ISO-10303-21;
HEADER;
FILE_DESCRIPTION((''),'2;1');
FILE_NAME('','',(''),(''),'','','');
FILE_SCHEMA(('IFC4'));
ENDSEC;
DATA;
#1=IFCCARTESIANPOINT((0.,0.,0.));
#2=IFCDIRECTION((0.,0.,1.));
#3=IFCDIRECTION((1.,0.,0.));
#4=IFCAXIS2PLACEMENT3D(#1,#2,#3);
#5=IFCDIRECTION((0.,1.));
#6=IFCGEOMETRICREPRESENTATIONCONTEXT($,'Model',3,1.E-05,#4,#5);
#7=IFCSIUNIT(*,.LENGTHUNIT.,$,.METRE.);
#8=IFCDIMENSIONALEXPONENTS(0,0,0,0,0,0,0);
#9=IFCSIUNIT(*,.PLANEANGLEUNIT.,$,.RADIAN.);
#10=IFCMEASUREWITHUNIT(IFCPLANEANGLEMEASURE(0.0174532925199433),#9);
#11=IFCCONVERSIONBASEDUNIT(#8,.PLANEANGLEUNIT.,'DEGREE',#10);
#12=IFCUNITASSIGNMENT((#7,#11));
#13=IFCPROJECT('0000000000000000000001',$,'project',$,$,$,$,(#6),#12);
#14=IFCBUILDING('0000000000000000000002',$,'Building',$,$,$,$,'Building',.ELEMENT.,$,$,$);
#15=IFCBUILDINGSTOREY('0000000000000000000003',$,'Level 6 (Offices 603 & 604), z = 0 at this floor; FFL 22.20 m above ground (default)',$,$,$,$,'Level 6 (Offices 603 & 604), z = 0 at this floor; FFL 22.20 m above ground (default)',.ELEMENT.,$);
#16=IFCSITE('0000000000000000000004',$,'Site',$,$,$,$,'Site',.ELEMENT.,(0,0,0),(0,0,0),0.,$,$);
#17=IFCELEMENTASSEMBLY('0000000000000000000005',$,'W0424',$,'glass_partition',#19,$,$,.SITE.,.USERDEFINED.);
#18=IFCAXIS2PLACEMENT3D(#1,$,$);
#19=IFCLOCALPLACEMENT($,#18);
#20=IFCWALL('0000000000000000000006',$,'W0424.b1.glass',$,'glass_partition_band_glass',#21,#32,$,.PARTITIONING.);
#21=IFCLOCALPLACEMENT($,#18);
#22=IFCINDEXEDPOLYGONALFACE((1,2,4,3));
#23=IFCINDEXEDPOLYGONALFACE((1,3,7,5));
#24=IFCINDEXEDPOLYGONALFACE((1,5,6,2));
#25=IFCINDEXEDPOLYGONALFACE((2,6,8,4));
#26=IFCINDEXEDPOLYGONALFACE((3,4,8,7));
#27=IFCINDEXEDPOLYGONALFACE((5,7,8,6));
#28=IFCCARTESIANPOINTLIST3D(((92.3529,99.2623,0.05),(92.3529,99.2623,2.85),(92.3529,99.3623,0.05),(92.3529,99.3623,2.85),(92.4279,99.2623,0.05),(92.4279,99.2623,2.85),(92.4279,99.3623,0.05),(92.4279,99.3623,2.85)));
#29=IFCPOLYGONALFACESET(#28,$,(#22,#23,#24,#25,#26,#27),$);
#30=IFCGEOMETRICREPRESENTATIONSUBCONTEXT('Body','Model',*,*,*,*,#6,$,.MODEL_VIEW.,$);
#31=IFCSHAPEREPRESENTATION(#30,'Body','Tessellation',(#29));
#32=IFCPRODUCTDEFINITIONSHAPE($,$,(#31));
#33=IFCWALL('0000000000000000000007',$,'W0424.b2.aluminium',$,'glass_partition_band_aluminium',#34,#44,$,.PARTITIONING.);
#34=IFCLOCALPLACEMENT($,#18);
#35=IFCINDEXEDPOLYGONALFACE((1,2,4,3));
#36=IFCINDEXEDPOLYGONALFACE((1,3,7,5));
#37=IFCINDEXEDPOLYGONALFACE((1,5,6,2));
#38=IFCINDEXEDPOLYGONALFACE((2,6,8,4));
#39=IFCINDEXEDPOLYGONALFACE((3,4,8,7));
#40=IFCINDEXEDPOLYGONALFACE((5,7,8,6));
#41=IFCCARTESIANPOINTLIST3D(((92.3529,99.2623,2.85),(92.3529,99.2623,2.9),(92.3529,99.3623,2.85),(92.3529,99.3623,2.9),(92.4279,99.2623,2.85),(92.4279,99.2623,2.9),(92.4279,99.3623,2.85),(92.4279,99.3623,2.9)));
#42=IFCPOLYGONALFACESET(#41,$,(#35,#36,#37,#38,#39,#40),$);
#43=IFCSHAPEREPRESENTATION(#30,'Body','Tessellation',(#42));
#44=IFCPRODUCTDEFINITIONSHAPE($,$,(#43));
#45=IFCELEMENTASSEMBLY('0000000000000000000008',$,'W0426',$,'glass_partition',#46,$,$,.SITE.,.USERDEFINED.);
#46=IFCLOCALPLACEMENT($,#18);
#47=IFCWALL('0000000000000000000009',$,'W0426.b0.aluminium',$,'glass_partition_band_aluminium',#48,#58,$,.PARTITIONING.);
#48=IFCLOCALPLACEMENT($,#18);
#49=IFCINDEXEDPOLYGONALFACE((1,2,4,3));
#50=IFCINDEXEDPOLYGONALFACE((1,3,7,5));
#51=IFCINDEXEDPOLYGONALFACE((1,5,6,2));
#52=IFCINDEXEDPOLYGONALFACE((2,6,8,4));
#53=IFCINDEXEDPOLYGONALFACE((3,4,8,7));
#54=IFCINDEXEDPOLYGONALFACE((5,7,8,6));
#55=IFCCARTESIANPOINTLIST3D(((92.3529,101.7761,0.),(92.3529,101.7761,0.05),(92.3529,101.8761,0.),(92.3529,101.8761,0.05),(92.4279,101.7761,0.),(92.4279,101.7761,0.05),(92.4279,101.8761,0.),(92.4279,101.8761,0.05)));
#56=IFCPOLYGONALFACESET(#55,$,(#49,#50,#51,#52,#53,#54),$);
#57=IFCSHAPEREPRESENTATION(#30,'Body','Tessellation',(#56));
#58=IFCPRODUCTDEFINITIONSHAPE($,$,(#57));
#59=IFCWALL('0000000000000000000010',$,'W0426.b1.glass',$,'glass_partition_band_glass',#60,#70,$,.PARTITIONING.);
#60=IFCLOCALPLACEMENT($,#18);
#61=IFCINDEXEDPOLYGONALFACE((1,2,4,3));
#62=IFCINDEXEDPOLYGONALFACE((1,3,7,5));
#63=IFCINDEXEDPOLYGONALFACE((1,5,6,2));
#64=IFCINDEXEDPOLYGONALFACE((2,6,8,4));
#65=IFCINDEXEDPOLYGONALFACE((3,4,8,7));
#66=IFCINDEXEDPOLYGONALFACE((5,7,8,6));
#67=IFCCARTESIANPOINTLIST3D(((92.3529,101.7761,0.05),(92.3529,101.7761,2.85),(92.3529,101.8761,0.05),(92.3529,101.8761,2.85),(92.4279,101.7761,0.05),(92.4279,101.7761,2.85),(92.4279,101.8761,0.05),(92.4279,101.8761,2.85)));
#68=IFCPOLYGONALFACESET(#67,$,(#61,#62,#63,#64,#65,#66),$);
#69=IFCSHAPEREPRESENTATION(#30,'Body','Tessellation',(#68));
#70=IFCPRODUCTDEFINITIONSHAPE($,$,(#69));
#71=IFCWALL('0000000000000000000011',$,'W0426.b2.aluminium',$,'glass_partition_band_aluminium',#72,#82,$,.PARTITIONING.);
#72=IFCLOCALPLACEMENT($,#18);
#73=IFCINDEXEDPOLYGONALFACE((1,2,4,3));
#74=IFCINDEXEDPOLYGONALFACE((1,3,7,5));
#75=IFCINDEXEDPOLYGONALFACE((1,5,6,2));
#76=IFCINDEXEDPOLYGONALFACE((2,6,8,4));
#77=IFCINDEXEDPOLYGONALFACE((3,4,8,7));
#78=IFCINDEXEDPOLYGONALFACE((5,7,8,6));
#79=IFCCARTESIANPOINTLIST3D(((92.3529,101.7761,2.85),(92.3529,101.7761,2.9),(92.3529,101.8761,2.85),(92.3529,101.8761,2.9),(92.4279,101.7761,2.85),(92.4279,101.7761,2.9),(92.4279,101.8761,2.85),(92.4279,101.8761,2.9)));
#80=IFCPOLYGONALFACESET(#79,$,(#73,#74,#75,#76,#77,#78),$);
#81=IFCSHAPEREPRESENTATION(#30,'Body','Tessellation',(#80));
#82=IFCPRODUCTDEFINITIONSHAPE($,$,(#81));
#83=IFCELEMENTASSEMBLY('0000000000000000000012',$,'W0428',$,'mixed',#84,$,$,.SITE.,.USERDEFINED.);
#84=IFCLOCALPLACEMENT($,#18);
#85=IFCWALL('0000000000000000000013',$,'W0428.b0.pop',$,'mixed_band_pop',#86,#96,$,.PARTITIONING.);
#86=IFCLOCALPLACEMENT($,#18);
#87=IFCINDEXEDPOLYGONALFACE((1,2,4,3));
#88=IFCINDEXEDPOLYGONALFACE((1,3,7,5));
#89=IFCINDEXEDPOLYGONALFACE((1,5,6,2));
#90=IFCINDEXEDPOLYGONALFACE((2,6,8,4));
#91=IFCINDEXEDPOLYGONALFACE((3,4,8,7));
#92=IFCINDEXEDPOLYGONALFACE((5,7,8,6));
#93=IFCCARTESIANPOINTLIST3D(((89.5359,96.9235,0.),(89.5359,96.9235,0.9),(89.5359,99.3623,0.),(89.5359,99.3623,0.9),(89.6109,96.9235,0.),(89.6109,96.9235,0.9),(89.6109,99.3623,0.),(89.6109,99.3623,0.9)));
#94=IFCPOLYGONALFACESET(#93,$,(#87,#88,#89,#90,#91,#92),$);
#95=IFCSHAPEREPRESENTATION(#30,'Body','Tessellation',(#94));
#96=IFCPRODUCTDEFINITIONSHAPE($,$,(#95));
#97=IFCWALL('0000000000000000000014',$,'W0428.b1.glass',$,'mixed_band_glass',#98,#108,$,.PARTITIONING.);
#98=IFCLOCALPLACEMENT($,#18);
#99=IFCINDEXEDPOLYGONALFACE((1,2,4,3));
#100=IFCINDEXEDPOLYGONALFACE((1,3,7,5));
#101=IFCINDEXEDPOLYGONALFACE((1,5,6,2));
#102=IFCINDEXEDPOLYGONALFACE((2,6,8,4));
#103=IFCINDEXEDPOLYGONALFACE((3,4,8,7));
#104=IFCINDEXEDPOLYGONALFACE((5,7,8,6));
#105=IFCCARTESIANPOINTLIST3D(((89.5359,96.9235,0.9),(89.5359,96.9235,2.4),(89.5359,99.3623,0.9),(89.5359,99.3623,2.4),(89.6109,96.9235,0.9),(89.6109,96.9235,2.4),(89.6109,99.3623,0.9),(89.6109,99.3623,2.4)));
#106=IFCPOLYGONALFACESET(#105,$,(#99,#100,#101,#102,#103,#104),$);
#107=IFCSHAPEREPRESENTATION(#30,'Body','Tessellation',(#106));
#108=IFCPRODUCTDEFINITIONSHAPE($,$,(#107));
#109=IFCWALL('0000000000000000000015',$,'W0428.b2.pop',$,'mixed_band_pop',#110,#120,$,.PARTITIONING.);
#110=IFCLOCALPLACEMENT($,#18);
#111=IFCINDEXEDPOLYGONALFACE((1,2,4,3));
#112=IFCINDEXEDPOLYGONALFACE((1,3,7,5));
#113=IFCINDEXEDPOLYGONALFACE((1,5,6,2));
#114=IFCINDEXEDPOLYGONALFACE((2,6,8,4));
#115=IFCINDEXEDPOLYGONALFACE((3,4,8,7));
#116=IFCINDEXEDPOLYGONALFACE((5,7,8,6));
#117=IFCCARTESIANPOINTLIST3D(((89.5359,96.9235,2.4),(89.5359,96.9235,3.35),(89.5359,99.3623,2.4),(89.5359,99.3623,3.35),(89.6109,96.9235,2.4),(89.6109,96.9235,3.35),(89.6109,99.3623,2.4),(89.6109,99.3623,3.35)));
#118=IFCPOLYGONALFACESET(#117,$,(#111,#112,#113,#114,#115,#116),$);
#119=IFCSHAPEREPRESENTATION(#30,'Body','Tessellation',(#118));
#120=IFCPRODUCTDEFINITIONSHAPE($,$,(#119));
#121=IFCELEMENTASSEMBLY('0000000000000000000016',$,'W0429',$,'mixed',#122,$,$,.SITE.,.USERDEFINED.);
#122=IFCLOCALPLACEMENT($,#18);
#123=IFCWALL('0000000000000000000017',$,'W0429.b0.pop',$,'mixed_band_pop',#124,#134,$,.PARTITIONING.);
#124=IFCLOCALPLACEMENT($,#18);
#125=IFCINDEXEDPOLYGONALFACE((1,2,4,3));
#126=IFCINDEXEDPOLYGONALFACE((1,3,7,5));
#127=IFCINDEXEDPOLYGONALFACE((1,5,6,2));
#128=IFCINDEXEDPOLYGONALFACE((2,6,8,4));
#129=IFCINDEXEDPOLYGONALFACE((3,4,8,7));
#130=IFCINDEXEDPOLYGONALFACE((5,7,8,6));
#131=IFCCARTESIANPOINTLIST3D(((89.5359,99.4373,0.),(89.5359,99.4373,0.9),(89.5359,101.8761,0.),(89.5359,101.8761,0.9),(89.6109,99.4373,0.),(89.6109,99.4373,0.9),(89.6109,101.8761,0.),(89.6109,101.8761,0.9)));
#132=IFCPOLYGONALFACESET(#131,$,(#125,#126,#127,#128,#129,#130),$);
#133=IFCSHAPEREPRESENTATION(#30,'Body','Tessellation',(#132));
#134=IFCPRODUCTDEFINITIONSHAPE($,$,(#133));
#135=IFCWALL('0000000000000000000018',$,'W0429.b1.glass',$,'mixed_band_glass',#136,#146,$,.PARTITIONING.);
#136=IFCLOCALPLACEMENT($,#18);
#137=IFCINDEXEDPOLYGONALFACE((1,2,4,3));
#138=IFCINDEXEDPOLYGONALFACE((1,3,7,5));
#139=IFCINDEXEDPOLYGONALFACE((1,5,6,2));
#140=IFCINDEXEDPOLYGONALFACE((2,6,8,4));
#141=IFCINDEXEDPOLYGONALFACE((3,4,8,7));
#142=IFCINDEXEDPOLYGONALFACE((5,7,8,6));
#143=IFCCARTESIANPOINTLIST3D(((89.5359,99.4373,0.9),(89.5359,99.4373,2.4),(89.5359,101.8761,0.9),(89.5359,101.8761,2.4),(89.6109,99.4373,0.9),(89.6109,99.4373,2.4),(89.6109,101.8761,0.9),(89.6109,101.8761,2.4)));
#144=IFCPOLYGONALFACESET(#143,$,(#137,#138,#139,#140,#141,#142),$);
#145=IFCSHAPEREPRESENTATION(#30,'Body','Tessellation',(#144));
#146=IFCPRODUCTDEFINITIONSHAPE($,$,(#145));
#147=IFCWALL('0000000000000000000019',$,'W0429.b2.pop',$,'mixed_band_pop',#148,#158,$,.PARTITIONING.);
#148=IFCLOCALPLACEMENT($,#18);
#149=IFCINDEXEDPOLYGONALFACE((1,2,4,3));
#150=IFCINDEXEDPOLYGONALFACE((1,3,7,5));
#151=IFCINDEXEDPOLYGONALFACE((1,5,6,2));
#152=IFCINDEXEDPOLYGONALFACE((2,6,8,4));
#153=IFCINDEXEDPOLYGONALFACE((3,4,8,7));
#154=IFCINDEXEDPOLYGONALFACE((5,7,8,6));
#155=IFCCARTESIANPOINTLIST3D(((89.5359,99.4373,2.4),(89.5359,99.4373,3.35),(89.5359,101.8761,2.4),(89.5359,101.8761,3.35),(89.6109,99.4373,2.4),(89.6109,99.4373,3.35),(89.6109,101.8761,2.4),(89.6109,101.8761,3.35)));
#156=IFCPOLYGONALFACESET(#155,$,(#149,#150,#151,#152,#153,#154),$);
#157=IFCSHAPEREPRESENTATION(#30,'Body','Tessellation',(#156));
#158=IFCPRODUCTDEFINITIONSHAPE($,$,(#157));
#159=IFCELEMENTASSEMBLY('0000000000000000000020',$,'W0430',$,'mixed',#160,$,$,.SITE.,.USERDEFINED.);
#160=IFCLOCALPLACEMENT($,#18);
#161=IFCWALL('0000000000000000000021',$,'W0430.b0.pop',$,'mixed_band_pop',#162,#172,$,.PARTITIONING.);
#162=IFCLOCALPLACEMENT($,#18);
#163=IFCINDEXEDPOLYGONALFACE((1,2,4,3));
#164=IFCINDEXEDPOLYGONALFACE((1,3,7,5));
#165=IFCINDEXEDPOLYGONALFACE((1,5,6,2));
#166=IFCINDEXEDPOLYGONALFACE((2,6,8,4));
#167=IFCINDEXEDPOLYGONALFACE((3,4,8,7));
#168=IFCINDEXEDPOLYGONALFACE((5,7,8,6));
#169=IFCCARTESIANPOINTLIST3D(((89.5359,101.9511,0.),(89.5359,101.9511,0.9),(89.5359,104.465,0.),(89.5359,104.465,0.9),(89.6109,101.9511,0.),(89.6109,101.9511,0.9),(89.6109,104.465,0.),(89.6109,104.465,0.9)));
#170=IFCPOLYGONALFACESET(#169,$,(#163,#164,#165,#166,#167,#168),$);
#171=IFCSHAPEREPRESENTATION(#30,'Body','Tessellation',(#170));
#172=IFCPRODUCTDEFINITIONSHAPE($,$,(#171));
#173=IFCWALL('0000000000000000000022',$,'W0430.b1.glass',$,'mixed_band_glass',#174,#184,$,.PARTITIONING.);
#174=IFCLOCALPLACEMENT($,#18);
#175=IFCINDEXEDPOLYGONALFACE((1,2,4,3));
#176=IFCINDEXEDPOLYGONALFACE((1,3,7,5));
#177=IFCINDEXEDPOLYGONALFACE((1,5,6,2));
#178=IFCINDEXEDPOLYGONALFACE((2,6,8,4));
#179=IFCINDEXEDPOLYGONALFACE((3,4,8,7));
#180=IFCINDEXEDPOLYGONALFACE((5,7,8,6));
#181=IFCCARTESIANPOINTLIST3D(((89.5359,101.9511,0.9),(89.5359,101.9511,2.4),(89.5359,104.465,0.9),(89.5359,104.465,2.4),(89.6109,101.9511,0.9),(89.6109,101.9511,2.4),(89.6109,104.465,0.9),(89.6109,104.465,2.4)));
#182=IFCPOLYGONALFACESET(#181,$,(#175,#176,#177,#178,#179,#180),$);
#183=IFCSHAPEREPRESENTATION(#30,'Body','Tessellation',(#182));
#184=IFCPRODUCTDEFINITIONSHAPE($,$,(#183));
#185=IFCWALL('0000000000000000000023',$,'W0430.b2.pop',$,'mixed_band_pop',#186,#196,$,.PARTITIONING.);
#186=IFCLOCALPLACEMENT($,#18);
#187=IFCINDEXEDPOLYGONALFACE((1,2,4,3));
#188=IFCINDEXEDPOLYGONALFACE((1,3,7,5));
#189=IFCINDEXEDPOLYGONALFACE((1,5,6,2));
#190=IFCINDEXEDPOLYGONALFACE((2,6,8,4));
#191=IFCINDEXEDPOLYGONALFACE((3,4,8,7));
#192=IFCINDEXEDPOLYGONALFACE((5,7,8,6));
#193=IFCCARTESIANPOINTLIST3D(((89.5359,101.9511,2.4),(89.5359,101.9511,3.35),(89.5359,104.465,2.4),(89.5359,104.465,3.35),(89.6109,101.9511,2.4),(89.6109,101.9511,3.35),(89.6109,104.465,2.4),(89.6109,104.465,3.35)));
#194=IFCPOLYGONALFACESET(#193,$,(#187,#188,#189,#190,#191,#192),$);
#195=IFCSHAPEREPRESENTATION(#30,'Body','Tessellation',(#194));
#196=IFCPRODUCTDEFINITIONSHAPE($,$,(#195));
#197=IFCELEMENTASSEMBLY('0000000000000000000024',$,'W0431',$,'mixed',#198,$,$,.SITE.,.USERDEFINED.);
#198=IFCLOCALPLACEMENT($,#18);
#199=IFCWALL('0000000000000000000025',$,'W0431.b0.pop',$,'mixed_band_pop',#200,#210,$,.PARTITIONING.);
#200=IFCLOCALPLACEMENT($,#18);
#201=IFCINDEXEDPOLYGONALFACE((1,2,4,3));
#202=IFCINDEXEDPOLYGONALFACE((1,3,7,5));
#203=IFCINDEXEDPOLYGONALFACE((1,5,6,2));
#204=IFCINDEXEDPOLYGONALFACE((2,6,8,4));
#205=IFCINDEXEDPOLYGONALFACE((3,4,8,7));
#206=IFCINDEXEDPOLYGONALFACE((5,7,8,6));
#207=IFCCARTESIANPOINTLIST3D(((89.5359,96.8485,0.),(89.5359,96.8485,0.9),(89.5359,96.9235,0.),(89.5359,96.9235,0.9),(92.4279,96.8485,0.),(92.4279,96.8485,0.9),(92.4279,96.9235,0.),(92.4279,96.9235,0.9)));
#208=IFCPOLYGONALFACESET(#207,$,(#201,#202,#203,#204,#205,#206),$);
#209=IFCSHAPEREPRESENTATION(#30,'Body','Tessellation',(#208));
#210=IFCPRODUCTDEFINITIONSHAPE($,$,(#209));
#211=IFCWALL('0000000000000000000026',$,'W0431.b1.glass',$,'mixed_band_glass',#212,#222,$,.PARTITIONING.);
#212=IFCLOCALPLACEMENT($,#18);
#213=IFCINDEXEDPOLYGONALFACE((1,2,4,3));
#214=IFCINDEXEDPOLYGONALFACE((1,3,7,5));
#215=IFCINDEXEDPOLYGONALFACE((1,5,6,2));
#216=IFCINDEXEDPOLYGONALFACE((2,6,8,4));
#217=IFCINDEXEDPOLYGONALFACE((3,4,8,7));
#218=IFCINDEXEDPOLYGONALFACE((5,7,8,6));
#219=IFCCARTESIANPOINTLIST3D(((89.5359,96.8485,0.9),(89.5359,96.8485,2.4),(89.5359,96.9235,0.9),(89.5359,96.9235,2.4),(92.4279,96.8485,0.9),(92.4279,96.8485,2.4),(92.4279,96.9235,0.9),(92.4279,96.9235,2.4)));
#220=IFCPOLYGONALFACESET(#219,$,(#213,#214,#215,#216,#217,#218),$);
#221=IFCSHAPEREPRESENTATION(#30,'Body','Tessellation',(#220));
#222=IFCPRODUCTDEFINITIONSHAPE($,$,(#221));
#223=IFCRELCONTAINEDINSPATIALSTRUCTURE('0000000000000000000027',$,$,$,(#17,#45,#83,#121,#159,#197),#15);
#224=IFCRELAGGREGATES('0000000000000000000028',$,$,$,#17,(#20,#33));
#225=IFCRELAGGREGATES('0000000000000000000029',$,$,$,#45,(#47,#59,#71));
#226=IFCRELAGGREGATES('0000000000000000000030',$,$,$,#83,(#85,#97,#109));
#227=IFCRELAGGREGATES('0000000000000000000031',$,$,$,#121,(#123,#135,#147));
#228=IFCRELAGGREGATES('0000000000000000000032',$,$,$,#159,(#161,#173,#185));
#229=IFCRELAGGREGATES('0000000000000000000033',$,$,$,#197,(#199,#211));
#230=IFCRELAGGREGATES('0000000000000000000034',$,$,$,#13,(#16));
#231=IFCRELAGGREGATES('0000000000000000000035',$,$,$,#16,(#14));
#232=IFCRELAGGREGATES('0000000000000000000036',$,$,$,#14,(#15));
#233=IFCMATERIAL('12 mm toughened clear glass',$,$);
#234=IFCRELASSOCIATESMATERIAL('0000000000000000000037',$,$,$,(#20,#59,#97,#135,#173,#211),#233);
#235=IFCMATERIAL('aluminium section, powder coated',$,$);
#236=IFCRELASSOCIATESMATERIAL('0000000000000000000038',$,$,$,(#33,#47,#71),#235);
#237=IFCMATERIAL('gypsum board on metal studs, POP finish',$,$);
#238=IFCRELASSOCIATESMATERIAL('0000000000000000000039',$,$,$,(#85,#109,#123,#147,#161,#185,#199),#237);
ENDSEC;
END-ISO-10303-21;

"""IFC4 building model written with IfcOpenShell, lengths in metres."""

from ifc_helpers import new_model, entity, si_unit, converted_unit, direction, frame, frame_2d, origin_with_axes, place, context, subcontext, project, spatial, rectangle, extrude, material, element, aggregate, save


model = new_model("IFC4")

# Units and contexts
model_context = context("Model", 3, precision=1e-05, world=origin_with_axes(), true_north=direction((0.0, 1.0)))
body_context = subcontext(model_context, "Body", "Model", "MODEL_VIEW")
ifc_project = project(units=[si_unit("LENGTHUNIT", "METRE"), converted_unit("PLANEANGLEUNIT", "DEGREE", entity("IfcPlaneAngleMeasure", 0.0174532925199433), si_unit("PLANEANGLEUNIT", "RADIAN"), dimensions=[0, 0, 0, 0, 0, 0, 0])], contexts=[model_context])

# Site, building, storey
site = spatial("IfcSite", under=ifc_project, Name="Site", LongName="Site", CompositionType="ELEMENT", RefLatitude=(0, 0, 0), RefLongitude=(0, 0, 0), RefElevation=0.0)
building = spatial("IfcBuilding", under=site, Name="Building", LongName="Building", CompositionType="ELEMENT")
storey = spatial("IfcBuildingStorey", under=building, Name="Level 6 (Offices 603 & 604), z = 0 at this floor; FFL 22.20 m above ground (default)", LongName="Level 6 (Offices 603 & 604), z = 0 at this floor; FFL 22.20 m above ground (default)", CompositionType="ELEMENT")

# Element assemblies, walls
assembly_1 = element("IfcElementAssembly", 1, inside=storey, Name="W0424", ObjectType="glass_partition", AssemblyPlace="SITE", PredefinedType="USERDEFINED")
ifc_material_1 = material(Name="12 mm toughened clear glass")
placement = place(None, origin_with_axes())
wall_1 = element("IfcWall", 2, at=placement, material=ifc_material_1, Name="W0424.b1.glass", ObjectType="glass_partition_band_glass", PredefinedType="PARTITIONING", context=body_context, shape_type="SweptSolid", body=[
    extrude(rectangle(XDim=0.1, YDim=0.075, at=frame_2d((0.0, 0.0), x_axis=(0.0, 1.0))), frame((92.3904, 99.3123, 0.05), z_axis=(0.0, 0.0, 1.0), x_axis=(1.0, 0.0, 0.0)), (0.0, 0.0, 1.0), 2.8),
])
ifc_material_2 = material(Name="aluminium section, powder coated")
wall_2 = element("IfcWall", 3, at=placement, material=ifc_material_2, Name="W0424.b2.aluminium", ObjectType="glass_partition_band_aluminium", PredefinedType="PARTITIONING", context=body_context, shape_type="SweptSolid", body=[
    extrude(rectangle(XDim=0.1, YDim=0.075, at=frame_2d((0.0, 0.0), x_axis=(0.0, 1.0))), frame((92.3904, 99.3123, 2.85), z_axis=(0.0, 0.0, 1.0), x_axis=(1.0, 0.0, 0.0)), (0.0, 0.0, 1.0), 0.05),
])
aggregate(assembly_1, [wall_1, wall_2])
assembly_2 = element("IfcElementAssembly", 4, inside=storey, Name="W0426", ObjectType="glass_partition", AssemblyPlace="SITE", PredefinedType="USERDEFINED")
wall_3 = element("IfcWall", 5, at=placement, material=ifc_material_2, Name="W0426.b0.aluminium", ObjectType="glass_partition_band_aluminium", PredefinedType="PARTITIONING", context=body_context, shape_type="SweptSolid", body=[
    extrude(rectangle(XDim=0.1, YDim=0.075, at=frame_2d((0.0, 0.0), x_axis=(0.0, 1.0))), frame((92.3904, 101.8261, 0.0), z_axis=(0.0, 0.0, 1.0), x_axis=(1.0, 0.0, 0.0)), (0.0, 0.0, 1.0), 0.05),
])
wall_4 = element("IfcWall", 6, at=placement, material=ifc_material_1, Name="W0426.b1.glass", ObjectType="glass_partition_band_glass", PredefinedType="PARTITIONING", context=body_context, shape_type="SweptSolid", body=[
    extrude(rectangle(XDim=0.1, YDim=0.075, at=frame_2d((0.0, 0.0), x_axis=(0.0, 1.0))), frame((92.3904, 101.8261, 0.05), z_axis=(0.0, 0.0, 1.0), x_axis=(1.0, 0.0, 0.0)), (0.0, 0.0, 1.0), 2.8),
])
wall_5 = element("IfcWall", 7, at=placement, material=ifc_material_2, Name="W0426.b2.aluminium", ObjectType="glass_partition_band_aluminium", PredefinedType="PARTITIONING", context=body_context, shape_type="SweptSolid", body=[
    extrude(rectangle(XDim=0.1, YDim=0.075, at=frame_2d((0.0, 0.0), x_axis=(0.0, 1.0))), frame((92.3904, 101.8261, 2.85), z_axis=(0.0, 0.0, 1.0), x_axis=(1.0, 0.0, 0.0)), (0.0, 0.0, 1.0), 0.05),
])
aggregate(assembly_2, [wall_3, wall_4, wall_5])
assembly_3 = element("IfcElementAssembly", 8, inside=storey, Name="W0428", ObjectType="mixed", AssemblyPlace="SITE", PredefinedType="USERDEFINED")
ifc_material_3 = material(Name="gypsum board on metal studs, POP finish")
wall_6 = element("IfcWall", 9, at=placement, material=ifc_material_3, Name="W0428.b0.pop", ObjectType="mixed_band_pop", PredefinedType="PARTITIONING", context=body_context, shape_type="SweptSolid", body=[
    extrude(rectangle(XDim=2.4388, YDim=0.075, at=frame_2d((0.0, 0.0), x_axis=(0.0, 1.0))), frame((89.5734, 98.1429, 0.0), z_axis=(0.0, 0.0, 1.0), x_axis=(1.0, 0.0, 0.0)), (0.0, 0.0, 1.0), 0.9),
])
wall_7 = element("IfcWall", 10, at=placement, material=ifc_material_1, Name="W0428.b1.glass", ObjectType="mixed_band_glass", PredefinedType="PARTITIONING", context=body_context, shape_type="SweptSolid", body=[
    extrude(rectangle(XDim=2.4388, YDim=0.075, at=frame_2d((0.0, 0.0), x_axis=(0.0, 1.0))), frame((89.5734, 98.1429, 0.9), z_axis=(0.0, 0.0, 1.0), x_axis=(1.0, 0.0, 0.0)), (0.0, 0.0, 1.0), 1.5),
])
wall_8 = element("IfcWall", 11, at=placement, material=ifc_material_3, Name="W0428.b2.pop", ObjectType="mixed_band_pop", PredefinedType="PARTITIONING", context=body_context, shape_type="SweptSolid", body=[
    extrude(rectangle(XDim=2.4388, YDim=0.075, at=frame_2d((0.0, 0.0), x_axis=(0.0, 1.0))), frame((89.5734, 98.1429, 2.4), z_axis=(0.0, 0.0, 1.0), x_axis=(1.0, 0.0, 0.0)), (0.0, 0.0, 1.0), 0.95),
])
aggregate(assembly_3, [wall_6, wall_7, wall_8])
assembly_4 = element("IfcElementAssembly", 12, inside=storey, Name="W0429", ObjectType="mixed", AssemblyPlace="SITE", PredefinedType="USERDEFINED")
wall_9 = element("IfcWall", 13, at=placement, material=ifc_material_3, Name="W0429.b0.pop", ObjectType="mixed_band_pop", PredefinedType="PARTITIONING", context=body_context, shape_type="SweptSolid", body=[
    extrude(rectangle(XDim=2.4388, YDim=0.075, at=frame_2d((0.0, 0.0), x_axis=(0.0, 1.0))), frame((89.5734, 100.6567, 0.0), z_axis=(0.0, 0.0, 1.0), x_axis=(1.0, 0.0, 0.0)), (0.0, 0.0, 1.0), 0.9),
])
wall_10 = element("IfcWall", 14, at=placement, material=ifc_material_1, Name="W0429.b1.glass", ObjectType="mixed_band_glass", PredefinedType="PARTITIONING", context=body_context, shape_type="SweptSolid", body=[
    extrude(rectangle(XDim=2.4388, YDim=0.075, at=frame_2d((0.0, 0.0), x_axis=(0.0, 1.0))), frame((89.5734, 100.6567, 0.9), z_axis=(0.0, 0.0, 1.0), x_axis=(1.0, 0.0, 0.0)), (0.0, 0.0, 1.0), 1.5),
])
wall_11 = element("IfcWall", 15, at=placement, material=ifc_material_3, Name="W0429.b2.pop", ObjectType="mixed_band_pop", PredefinedType="PARTITIONING", context=body_context, shape_type="SweptSolid", body=[
    extrude(rectangle(XDim=2.4388, YDim=0.075, at=frame_2d((0.0, 0.0), x_axis=(0.0, 1.0))), frame((89.5734, 100.6567, 2.4), z_axis=(0.0, 0.0, 1.0), x_axis=(1.0, 0.0, 0.0)), (0.0, 0.0, 1.0), 0.95),
])
aggregate(assembly_4, [wall_9, wall_10, wall_11])
assembly_5 = element("IfcElementAssembly", 16, inside=storey, Name="W0430", ObjectType="mixed", AssemblyPlace="SITE", PredefinedType="USERDEFINED")
wall_12 = element("IfcWall", 17, at=placement, material=ifc_material_3, Name="W0430.b0.pop", ObjectType="mixed_band_pop", PredefinedType="PARTITIONING", context=body_context, shape_type="SweptSolid", body=[
    extrude(rectangle(XDim=2.5139, YDim=0.075, at=frame_2d((0.0, 0.0), x_axis=(0.0, 1.0))), frame((89.5734, 103.2081, 0.0), z_axis=(0.0, 0.0, 1.0), x_axis=(1.0, 0.0, 0.0)), (0.0, 0.0, 1.0), 0.9),
])
wall_13 = element("IfcWall", 18, at=placement, material=ifc_material_1, Name="W0430.b1.glass", ObjectType="mixed_band_glass", PredefinedType="PARTITIONING", context=body_context, shape_type="SweptSolid", body=[
    extrude(rectangle(XDim=2.5139, YDim=0.075, at=frame_2d((0.0, 0.0), x_axis=(0.0, 1.0))), frame((89.5734, 103.2081, 0.9), z_axis=(0.0, 0.0, 1.0), x_axis=(1.0, 0.0, 0.0)), (0.0, 0.0, 1.0), 1.5),
])
wall_14 = element("IfcWall", 19, at=placement, material=ifc_material_3, Name="W0430.b2.pop", ObjectType="mixed_band_pop", PredefinedType="PARTITIONING", context=body_context, shape_type="SweptSolid", body=[
    extrude(rectangle(XDim=2.5139, YDim=0.075, at=frame_2d((0.0, 0.0), x_axis=(0.0, 1.0))), frame((89.5734, 103.2081, 2.4), z_axis=(0.0, 0.0, 1.0), x_axis=(1.0, 0.0, 0.0)), (0.0, 0.0, 1.0), 0.95),
])
aggregate(assembly_5, [wall_12, wall_13, wall_14])
assembly_6 = element("IfcElementAssembly", 20, inside=storey, Name="W0431", ObjectType="mixed", AssemblyPlace="SITE", PredefinedType="USERDEFINED")
wall_15 = element("IfcWall", 21, at=placement, material=ifc_material_3, Name="W0431.b0.pop", ObjectType="mixed_band_pop", PredefinedType="PARTITIONING", context=body_context, shape_type="SweptSolid", body=[
    extrude(rectangle(XDim=2.892, YDim=0.075, at=frame_2d((0.0, 0.0), x_axis=(1.0, 0.0))), frame((90.9819, 96.886, 0.0), z_axis=(0.0, 0.0, 1.0), x_axis=(1.0, 0.0, 0.0)), (0.0, 0.0, 1.0), 0.9),
])
wall_16 = element("IfcWall", 22, at=placement, material=ifc_material_1, Name="W0431.b1.glass", ObjectType="mixed_band_glass", PredefinedType="PARTITIONING", context=body_context, shape_type="SweptSolid", body=[
    extrude(rectangle(XDim=2.892, YDim=0.075, at=frame_2d((0.0, 0.0), x_axis=(1.0, 0.0))), frame((90.9819, 96.886, 0.9), z_axis=(0.0, 0.0, 1.0), x_axis=(1.0, 0.0, 0.0)), (0.0, 0.0, 1.0), 1.5),
])
aggregate(assembly_6, [wall_15, wall_16])

save(model, "model.ifc")
